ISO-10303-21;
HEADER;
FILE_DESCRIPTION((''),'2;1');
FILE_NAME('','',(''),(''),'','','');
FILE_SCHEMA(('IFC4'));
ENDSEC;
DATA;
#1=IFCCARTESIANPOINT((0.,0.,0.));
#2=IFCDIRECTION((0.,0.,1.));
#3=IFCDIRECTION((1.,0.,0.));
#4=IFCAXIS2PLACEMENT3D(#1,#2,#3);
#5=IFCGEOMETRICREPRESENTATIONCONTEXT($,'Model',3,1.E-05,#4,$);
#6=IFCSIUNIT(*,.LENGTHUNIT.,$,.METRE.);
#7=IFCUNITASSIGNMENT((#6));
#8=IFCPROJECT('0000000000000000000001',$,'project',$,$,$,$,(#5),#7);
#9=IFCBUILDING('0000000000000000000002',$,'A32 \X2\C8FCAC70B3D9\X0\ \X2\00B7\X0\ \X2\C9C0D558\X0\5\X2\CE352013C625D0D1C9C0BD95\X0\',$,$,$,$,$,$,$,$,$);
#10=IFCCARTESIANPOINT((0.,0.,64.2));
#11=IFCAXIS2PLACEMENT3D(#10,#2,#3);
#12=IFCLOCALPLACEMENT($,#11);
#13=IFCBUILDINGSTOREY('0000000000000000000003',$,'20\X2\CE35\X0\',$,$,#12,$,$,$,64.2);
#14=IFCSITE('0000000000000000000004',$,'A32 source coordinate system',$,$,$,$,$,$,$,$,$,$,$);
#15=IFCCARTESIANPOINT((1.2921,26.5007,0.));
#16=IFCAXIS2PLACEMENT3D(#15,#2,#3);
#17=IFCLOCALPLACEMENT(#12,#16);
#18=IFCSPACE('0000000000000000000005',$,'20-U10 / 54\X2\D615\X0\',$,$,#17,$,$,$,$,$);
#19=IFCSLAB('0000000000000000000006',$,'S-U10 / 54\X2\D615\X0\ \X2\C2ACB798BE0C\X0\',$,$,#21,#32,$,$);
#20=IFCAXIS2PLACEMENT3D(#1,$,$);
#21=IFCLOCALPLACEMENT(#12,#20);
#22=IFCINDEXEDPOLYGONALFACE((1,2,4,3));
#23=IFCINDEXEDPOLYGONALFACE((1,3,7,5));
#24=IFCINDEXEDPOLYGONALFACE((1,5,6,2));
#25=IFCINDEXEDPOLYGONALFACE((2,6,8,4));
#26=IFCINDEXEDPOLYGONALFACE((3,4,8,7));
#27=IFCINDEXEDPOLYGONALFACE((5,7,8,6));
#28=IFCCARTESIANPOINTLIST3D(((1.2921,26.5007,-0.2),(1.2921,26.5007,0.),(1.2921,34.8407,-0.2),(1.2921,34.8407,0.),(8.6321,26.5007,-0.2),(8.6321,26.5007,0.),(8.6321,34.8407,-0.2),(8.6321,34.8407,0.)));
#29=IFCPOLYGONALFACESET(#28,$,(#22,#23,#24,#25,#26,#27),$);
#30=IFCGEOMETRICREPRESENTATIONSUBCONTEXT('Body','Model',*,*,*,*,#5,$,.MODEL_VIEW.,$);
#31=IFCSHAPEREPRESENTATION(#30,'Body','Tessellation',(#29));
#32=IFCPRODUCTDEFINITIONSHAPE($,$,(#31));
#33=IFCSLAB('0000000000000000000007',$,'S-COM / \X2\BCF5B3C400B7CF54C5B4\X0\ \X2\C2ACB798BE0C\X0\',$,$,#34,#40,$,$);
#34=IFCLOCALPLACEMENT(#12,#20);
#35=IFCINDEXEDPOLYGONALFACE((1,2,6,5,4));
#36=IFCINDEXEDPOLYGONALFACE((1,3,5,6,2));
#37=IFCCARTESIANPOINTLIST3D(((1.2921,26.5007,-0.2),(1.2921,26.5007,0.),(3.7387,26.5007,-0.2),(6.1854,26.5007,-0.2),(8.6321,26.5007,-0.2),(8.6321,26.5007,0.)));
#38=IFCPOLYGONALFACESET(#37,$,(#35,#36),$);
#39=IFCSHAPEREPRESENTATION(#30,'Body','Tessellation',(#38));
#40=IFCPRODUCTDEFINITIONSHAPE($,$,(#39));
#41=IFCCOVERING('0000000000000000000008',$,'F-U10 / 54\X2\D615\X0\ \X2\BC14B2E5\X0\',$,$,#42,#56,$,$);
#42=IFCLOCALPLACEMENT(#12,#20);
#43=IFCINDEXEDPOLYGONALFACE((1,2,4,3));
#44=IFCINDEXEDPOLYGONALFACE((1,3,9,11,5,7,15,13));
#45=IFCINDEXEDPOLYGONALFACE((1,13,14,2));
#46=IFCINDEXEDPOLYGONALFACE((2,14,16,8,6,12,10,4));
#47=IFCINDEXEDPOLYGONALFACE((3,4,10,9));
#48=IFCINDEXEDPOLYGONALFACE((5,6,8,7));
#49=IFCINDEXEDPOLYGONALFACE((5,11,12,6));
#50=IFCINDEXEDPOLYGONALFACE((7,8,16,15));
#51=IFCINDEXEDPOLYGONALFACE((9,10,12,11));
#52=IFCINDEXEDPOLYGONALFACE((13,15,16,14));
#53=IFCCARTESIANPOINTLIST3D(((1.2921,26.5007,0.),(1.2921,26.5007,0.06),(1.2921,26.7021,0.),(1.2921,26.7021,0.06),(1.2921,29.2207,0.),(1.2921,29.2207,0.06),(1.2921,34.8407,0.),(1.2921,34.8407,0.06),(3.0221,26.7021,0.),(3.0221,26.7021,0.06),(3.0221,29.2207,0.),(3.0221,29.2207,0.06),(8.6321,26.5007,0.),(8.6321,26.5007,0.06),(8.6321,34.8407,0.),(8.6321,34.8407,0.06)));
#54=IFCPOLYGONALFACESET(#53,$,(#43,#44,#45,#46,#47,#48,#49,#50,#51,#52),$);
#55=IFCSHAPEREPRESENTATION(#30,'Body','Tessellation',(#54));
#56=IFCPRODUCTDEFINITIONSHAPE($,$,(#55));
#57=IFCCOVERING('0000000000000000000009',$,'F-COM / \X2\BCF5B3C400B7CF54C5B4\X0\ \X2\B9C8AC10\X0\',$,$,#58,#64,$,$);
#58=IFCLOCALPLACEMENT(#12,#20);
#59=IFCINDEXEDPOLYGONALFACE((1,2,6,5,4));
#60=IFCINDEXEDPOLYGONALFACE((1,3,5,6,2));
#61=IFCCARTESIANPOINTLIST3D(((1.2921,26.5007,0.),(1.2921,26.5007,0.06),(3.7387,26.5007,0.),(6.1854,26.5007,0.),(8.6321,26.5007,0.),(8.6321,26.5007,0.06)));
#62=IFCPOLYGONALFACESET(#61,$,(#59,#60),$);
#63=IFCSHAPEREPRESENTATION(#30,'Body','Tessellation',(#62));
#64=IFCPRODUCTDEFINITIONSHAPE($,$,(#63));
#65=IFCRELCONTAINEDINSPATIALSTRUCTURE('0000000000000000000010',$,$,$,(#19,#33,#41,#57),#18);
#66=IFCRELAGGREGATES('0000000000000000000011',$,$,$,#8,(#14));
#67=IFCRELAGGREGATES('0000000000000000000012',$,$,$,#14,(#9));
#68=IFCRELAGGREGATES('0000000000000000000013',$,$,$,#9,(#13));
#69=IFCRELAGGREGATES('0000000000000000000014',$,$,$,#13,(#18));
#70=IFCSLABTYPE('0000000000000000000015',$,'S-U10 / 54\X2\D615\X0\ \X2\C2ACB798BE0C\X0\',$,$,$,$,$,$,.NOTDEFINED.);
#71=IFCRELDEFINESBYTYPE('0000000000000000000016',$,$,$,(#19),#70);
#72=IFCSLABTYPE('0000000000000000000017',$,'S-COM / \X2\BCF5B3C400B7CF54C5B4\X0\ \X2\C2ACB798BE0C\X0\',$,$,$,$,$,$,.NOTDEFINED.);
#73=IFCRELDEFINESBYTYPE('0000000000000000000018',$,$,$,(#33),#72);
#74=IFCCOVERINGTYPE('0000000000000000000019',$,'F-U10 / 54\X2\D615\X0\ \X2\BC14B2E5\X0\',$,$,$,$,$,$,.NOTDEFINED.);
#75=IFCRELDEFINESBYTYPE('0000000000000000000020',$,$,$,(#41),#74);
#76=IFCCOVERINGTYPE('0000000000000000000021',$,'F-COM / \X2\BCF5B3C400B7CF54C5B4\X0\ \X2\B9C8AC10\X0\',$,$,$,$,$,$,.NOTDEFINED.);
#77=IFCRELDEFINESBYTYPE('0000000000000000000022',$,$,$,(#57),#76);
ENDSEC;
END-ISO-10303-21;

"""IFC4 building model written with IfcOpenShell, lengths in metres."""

from ifc_helpers import new_model, si_unit, frame, origin, origin_with_axes, place, context, subcontext, project, spatial, polyline, outline, extrude, source, transform, mapped, type_object, type_shapes, element, save


model = new_model("IFC4")

# Units and contexts
model_context = context("Model", 3, precision=1e-05, world=origin_with_axes())
body_context = subcontext(model_context, "Body", "Model", "MODEL_VIEW")
ifc_project = project(units=[si_unit("LENGTHUNIT", "METRE")], contexts=[model_context])

# Site, building, storey, space
storey_placement = place(None, frame((0.0, 0.0, 64.2), z_axis=(0.0, 0.0, 1.0), x_axis=(1.0, 0.0, 0.0)))
space_placement = place(storey_placement, frame((1.2921, 26.5007, 0.0), z_axis=(0.0, 0.0, 1.0), x_axis=(1.0, 0.0, 0.0)))
site = spatial("IfcSite", under=ifc_project, Name="A32 source coordinate system")
building = spatial("IfcBuilding", under=site, Name="A32 주거동 · 지하5층–옥탑지붕")
storey = spatial("IfcBuildingStorey", under=building, at=storey_placement, Name="20층", Elevation=64.2)
space = spatial("IfcSpace", under=storey, at=space_placement, Name="20-U10 / 54형")

# Slabs
slab_type_1 = type_object("IfcSlabType", Name="S-U10 / 54형 슬래브", PredefinedType="NOTDEFINED")
shared_shape_1 = source(origin(), body_context, "Body", "SweptSolid", [
    extrude(outline(polyline([(0.0, 0.0), (0.0, 8.34), (7.34, 8.34), (7.34, 0.0), (0.0, 0.0)])), frame((0.0, 0.0, -0.2)), (0.0, 0.0, 1.0), 0.2),
])
type_shapes(slab_type_1, [shared_shape_1])
slab_1_placement = place(space_placement, origin_with_axes())
element("IfcSlab", 1, at=slab_1_placement, inside=space, type_object=slab_type_1, Name="S-U10 / 54형 슬래브", context=body_context, shape_type="MappedRepresentation", body=[
    mapped(shared_shape_1, transform((0.0, 0.0, 0.0), scale=1.0)),
])
slab_type_2 = type_object("IfcSlabType", Name="S-COM / 복도·코어 슬래브", PredefinedType="NOTDEFINED")
shared_shape_2 = source(origin(), body_context, "Body", "SweptSolid", [
    extrude(outline(polyline([(7.34, 0.0), (7.34, 0.0), (0.0, 0.0), (0.0, 0.0), (7.34, 0.0)])), frame((0.0, 0.0, -0.2)), (0.0, 0.0, 1.0), 0.2),
])
type_shapes(slab_type_2, [shared_shape_2])
slab_2_placement = place(space_placement, origin_with_axes())
element("IfcSlab", 2, at=slab_2_placement, inside=space, type_object=slab_type_2, Name="S-COM / 복도·코어 슬래브", context=body_context, shape_type="MappedRepresentation", body=[
    mapped(shared_shape_2, transform((0.0, 0.0, 0.0), scale=1.0)),
])

# Coverings
covering_type_1 = type_object("IfcCoveringType", Name="F-U10 / 54형 바닥", PredefinedType="NOTDEFINED")
shared_shape_3 = source(origin(), body_context, "Body", "SweptSolid", [
    extrude(outline(polyline([(7.34, 0.0), (0.0, 0.0), (0.0, 0.2014), (1.73, 0.2014), (1.73, 2.72), (0.0, 2.72), (0.0, 8.34), (7.34, 8.34), (7.34, 0.0)])), origin(), (0.0, 0.0, 1.0), 0.06),
])
type_shapes(covering_type_1, [shared_shape_3])
covering_1_placement = place(space_placement, origin_with_axes())
element("IfcCovering", 3, at=covering_1_placement, inside=space, type_object=covering_type_1, Name="F-U10 / 54형 바닥", context=body_context, shape_type="MappedRepresentation", body=[
    mapped(shared_shape_3, transform((0.0, 0.0, 0.0), scale=1.0)),
])
covering_type_2 = type_object("IfcCoveringType", Name="F-COM / 복도·코어 마감", PredefinedType="NOTDEFINED")
shared_shape_4 = source(origin(), body_context, "Body", "SweptSolid", [
    extrude(outline(polyline([(7.34, 0.0), (7.34, 0.0), (0.0, 0.0), (0.0, 0.0), (7.34, 0.0)])), origin(), (0.0, 0.0, 1.0), 0.06),
])
type_shapes(covering_type_2, [shared_shape_4])
covering_2_placement = place(space_placement, origin_with_axes())
element("IfcCovering", 4, at=covering_2_placement, inside=space, type_object=covering_type_2, Name="F-COM / 복도·코어 마감", context=body_context, shape_type="MappedRepresentation", body=[
    mapped(shared_shape_4, transform((0.0, 0.0, 0.0), scale=1.0)),
])

save(model, "model.ifc")
